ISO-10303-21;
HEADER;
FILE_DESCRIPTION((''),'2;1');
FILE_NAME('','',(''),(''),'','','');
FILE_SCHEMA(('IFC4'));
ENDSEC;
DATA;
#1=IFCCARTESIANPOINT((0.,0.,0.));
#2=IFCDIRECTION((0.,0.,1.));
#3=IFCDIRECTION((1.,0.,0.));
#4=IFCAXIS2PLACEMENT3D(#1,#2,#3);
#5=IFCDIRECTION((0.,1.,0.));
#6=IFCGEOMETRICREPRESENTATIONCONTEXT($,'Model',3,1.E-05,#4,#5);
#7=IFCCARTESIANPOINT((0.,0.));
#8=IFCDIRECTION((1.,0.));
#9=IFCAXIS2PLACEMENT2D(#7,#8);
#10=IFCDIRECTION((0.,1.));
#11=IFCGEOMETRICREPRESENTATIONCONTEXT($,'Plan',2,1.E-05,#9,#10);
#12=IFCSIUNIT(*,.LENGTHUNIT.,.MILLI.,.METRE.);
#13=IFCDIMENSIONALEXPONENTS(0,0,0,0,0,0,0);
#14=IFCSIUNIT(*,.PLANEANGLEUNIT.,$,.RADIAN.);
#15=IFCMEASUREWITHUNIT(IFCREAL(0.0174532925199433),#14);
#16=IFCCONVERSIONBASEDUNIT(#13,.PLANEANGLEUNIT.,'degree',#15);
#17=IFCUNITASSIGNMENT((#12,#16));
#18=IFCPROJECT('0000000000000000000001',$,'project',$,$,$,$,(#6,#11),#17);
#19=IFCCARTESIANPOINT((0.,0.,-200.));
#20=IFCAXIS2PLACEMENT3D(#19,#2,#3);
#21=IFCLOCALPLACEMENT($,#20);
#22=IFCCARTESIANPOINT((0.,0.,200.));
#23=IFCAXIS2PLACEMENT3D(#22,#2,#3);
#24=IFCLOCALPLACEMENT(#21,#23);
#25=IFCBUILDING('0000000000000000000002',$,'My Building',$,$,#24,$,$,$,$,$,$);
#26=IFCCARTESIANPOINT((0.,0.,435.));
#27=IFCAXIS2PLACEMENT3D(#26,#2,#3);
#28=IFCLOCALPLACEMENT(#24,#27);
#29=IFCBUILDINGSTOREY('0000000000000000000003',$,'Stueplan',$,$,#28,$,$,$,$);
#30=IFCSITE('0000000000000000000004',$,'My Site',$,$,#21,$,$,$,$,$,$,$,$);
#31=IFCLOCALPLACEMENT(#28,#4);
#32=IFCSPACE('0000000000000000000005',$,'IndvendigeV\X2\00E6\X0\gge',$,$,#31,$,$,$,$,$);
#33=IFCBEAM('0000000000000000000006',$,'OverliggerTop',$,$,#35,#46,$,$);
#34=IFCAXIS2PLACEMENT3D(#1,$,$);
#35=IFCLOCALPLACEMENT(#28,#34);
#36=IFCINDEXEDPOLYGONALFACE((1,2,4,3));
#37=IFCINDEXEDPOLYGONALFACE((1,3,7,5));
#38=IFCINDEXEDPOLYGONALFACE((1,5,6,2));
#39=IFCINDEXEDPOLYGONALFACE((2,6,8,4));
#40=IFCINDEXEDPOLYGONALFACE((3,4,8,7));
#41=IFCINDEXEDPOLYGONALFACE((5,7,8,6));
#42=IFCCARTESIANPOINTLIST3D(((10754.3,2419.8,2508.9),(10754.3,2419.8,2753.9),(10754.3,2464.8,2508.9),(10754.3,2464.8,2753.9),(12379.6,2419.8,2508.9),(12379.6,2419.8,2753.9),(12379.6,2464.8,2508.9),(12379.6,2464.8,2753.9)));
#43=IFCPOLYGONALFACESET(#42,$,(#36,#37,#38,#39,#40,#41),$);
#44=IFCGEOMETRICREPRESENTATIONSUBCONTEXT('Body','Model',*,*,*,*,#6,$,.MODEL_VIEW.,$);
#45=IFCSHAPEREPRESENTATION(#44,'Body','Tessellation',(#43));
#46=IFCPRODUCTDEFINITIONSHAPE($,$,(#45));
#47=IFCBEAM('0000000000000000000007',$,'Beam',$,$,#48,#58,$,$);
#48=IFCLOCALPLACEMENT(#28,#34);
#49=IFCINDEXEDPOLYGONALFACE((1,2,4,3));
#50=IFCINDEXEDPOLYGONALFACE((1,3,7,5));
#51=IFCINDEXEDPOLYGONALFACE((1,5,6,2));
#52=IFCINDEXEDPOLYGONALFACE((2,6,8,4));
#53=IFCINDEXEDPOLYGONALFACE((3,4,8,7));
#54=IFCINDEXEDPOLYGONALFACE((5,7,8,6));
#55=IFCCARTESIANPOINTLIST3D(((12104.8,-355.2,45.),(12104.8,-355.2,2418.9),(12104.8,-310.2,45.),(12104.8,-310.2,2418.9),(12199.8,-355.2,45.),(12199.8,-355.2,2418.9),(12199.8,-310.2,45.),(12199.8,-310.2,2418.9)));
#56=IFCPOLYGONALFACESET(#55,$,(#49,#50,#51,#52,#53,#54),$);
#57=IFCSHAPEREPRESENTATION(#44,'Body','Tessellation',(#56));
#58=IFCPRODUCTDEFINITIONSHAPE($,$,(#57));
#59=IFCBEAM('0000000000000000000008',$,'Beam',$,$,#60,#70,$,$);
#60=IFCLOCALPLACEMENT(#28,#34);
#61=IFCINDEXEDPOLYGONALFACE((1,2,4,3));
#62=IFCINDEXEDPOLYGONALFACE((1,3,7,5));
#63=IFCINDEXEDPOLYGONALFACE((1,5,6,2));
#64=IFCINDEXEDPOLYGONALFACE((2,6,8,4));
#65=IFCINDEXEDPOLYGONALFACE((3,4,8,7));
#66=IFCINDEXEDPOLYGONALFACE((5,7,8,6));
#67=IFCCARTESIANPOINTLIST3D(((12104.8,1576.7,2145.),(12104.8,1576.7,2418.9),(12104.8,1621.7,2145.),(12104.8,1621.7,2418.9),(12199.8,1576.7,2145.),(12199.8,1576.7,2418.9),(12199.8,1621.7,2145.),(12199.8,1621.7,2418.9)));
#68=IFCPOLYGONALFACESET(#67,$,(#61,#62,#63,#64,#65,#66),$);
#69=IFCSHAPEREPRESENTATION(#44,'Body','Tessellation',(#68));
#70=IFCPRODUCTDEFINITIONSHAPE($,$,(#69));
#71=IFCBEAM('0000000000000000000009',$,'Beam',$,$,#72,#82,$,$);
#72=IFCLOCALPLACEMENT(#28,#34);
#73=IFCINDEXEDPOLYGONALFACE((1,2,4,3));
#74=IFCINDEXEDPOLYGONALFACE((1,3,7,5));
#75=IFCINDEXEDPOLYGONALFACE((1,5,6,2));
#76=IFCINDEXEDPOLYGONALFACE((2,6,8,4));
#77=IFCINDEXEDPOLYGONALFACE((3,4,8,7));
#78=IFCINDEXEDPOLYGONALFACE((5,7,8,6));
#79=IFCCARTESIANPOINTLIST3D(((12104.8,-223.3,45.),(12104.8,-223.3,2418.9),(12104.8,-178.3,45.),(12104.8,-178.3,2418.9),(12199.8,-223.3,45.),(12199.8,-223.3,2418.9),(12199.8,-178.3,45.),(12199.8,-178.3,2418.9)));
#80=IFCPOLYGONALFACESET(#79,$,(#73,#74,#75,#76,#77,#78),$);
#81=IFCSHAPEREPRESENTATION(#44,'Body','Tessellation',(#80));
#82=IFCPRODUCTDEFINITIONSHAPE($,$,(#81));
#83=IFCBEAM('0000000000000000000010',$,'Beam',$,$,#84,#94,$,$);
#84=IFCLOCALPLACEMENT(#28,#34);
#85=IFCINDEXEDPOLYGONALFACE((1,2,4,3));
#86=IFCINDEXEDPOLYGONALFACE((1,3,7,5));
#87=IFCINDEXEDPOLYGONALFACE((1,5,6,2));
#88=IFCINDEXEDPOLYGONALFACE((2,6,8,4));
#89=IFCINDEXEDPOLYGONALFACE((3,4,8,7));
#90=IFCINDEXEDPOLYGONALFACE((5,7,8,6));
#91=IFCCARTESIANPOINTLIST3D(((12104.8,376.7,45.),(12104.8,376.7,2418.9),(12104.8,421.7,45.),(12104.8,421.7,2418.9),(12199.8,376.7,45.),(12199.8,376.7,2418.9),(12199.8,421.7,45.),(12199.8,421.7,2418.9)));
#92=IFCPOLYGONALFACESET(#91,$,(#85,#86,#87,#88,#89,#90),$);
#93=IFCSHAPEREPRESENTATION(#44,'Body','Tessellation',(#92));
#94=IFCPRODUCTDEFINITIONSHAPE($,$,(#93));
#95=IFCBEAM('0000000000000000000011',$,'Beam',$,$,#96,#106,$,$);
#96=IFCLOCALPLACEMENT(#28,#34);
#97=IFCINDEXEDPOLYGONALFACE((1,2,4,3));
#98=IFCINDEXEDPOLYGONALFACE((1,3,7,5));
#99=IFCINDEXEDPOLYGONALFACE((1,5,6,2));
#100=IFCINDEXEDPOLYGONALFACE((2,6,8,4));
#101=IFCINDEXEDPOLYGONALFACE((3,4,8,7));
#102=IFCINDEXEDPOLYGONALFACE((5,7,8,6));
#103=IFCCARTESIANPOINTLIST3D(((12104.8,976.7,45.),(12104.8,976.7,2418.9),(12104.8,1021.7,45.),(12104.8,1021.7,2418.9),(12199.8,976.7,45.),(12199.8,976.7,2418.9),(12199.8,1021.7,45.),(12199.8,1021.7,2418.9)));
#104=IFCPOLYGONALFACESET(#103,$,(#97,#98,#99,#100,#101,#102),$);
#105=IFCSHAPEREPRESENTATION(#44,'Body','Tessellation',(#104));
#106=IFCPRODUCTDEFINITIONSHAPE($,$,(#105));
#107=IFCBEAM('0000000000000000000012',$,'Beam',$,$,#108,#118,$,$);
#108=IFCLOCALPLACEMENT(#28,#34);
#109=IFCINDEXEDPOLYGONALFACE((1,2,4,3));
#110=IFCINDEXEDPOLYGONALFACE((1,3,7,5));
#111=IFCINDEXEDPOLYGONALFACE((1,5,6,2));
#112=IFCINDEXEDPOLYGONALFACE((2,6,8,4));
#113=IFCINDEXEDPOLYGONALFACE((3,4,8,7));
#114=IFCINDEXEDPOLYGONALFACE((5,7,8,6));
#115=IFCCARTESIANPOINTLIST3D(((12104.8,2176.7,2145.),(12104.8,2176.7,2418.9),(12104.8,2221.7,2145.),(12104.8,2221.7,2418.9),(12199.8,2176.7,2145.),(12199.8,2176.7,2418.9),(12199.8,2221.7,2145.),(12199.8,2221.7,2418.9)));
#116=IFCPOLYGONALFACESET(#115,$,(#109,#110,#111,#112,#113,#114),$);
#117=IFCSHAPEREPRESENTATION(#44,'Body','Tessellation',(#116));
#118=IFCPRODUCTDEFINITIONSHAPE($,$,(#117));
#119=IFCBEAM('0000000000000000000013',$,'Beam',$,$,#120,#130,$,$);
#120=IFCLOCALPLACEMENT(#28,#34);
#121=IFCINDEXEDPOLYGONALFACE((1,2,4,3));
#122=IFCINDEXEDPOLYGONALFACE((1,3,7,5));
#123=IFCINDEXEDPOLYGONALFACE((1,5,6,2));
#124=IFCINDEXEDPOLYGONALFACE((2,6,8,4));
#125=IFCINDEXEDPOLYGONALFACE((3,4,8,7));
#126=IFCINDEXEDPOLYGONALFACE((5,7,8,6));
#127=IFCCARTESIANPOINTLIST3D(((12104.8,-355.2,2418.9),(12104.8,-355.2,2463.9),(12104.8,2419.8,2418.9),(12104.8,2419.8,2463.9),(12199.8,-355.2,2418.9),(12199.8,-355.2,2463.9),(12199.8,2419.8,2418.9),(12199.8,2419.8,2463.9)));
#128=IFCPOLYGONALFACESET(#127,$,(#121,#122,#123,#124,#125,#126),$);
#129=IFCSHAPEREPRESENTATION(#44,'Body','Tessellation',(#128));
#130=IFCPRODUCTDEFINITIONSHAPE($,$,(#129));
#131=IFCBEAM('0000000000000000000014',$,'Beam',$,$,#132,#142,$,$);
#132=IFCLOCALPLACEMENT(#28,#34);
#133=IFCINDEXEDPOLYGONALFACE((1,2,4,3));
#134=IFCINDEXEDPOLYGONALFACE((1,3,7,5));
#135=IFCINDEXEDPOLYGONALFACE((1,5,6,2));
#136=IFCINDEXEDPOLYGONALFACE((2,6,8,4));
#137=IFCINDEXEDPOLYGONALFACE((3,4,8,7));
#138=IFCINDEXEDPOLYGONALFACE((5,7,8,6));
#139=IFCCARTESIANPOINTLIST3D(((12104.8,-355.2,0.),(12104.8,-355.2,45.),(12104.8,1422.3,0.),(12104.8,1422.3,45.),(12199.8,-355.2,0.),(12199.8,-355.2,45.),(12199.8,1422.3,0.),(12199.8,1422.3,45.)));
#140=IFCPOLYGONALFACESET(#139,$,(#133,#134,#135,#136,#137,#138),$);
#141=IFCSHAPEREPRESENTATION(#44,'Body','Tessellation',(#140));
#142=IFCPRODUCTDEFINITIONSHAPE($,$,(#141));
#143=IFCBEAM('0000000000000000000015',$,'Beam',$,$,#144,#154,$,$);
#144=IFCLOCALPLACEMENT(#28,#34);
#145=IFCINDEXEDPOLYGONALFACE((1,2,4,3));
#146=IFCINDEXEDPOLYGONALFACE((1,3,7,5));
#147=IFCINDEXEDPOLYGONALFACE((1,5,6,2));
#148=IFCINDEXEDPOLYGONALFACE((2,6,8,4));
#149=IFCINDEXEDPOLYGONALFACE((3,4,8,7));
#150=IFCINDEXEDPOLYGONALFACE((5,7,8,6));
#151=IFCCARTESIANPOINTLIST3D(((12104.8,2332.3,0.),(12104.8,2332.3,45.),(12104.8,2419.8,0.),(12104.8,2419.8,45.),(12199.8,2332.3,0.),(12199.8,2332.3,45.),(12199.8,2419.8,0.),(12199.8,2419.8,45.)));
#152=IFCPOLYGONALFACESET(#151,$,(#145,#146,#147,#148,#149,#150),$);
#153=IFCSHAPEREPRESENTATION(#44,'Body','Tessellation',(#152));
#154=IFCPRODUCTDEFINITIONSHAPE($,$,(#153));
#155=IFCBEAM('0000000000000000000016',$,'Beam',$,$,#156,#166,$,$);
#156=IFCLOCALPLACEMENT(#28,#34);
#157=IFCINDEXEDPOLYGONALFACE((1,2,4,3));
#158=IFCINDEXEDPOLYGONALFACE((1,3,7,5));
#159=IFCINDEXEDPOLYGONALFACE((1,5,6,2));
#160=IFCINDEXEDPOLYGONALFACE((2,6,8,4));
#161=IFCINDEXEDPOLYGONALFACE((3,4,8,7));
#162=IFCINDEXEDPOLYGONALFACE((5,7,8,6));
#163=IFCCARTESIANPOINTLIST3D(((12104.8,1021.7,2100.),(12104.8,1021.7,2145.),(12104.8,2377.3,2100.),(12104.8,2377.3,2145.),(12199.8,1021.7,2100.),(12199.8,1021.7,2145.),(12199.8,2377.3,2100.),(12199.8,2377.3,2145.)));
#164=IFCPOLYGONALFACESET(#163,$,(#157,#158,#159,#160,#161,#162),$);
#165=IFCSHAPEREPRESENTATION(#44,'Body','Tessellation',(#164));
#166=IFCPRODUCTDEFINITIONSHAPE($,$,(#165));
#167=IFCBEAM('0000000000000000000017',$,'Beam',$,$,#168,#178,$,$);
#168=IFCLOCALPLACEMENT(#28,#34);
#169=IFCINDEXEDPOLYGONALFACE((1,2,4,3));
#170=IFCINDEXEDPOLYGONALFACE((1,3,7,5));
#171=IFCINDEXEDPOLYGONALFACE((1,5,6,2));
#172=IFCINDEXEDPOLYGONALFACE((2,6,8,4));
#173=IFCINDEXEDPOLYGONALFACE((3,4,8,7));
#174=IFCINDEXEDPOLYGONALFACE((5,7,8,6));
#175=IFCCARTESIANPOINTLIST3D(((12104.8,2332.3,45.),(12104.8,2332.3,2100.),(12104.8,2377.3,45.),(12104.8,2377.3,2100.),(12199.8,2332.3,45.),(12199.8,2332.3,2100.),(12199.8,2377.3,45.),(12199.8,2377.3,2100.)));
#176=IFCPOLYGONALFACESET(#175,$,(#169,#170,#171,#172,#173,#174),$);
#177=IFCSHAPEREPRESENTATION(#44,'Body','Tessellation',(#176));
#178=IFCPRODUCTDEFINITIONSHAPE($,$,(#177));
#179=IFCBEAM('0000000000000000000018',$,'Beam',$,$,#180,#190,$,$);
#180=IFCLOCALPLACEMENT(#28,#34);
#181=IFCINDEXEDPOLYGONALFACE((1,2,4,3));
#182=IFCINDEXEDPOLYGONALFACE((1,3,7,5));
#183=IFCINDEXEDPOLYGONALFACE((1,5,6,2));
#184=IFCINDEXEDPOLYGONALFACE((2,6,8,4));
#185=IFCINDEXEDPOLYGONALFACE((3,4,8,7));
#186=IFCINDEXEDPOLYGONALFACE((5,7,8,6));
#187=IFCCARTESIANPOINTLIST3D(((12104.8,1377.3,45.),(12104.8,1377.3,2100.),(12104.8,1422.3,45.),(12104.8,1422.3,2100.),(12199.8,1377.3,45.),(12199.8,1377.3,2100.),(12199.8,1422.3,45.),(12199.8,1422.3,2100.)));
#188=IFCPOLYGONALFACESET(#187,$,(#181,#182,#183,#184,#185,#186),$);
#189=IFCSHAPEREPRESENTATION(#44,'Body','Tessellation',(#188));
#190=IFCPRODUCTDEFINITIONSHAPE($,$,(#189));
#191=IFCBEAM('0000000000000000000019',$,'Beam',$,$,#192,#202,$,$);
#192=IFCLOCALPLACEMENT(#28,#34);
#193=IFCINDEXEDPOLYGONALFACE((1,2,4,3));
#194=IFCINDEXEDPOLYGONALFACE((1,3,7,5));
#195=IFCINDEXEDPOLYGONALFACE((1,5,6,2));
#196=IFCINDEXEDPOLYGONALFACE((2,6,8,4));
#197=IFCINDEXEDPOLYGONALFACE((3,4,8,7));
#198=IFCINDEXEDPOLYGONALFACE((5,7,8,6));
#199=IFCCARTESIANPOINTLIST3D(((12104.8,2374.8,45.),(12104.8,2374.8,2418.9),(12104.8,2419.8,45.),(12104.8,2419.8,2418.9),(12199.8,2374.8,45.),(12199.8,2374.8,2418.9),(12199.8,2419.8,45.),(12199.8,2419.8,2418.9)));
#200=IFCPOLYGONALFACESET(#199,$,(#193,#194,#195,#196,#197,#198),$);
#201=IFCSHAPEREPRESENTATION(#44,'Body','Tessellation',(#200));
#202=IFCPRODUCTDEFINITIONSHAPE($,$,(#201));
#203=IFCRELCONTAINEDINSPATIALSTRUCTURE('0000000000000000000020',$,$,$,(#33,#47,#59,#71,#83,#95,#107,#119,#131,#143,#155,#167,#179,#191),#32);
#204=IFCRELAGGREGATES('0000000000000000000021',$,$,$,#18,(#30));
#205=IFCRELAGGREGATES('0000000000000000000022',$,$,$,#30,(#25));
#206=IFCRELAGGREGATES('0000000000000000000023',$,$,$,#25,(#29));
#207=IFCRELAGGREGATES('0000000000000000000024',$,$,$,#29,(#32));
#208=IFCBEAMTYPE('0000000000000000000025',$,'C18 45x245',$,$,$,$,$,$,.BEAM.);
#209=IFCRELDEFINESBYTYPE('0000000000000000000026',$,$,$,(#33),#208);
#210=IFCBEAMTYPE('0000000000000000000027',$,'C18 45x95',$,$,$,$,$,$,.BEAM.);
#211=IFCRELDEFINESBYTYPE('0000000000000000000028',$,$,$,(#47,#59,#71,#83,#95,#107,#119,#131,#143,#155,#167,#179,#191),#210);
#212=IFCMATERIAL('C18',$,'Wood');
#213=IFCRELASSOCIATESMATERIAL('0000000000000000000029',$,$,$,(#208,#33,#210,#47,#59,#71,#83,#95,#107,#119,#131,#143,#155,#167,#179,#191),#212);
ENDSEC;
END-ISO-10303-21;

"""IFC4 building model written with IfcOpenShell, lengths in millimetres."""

from ifc_helpers import new_model, entity, si_unit, converted_unit, direction, frame, origin_with_axes, origin_2d_with_axis, place, context, subcontext, project, spatial, rectangle, extrude, material, material_profile, profile_set, profile_usage, type_object, element, save


model = new_model("IFC4")

# Units and contexts
model_context = context("Model", 3, precision=1e-05, world=origin_with_axes(), true_north=direction((0.0, 1.0, 0.0)))
plan_context = context("Plan", 2, precision=1e-05, world=origin_2d_with_axis(), true_north=direction((0.0, 1.0)))
body_context_1 = subcontext(model_context, "Body", "Model", "MODEL_VIEW")
ifc_project = project(units=[si_unit("LENGTHUNIT", "METRE", prefix="MILLI"), converted_unit("PLANEANGLEUNIT", "degree", entity("IfcReal", 0.0174532925199433), si_unit("PLANEANGLEUNIT", "RADIAN"), dimensions=[0, 0, 0, 0, 0, 0, 0])], contexts=[model_context, plan_context])

# Site, building, storey
site_placement = place(None, frame((0.0, 0.0, -200.0), z_axis=(0.0, 0.0, 1.0), x_axis=(1.0, 0.0, 0.0)))
site = spatial("IfcSite", under=ifc_project, at=site_placement, Name="My Site")
building_placement = place(site_placement, frame((0.0, 0.0, 200.0), z_axis=(0.0, 0.0, 1.0), x_axis=(1.0, 0.0, 0.0)))
building = spatial("IfcBuilding", under=site, at=building_placement, Name="My Building")
storey_placement = place(building_placement, frame((0.0, 0.0, 435.0), z_axis=(0.0, 0.0, 1.0), x_axis=(1.0, 0.0, 0.0)))
storey = spatial("IfcBuildingStorey", under=building, at=storey_placement, Name="Stueplan")

# Shared definitions
ifc_material = material(Name="C18", Category="Wood")

# Shared definitions
space_1_placement = place(storey_placement, frame((0.0, 0.0, 0.0), z_axis=(0.0, 0.0, 1.0), x_axis=(1.0, 0.0, 0.0)))
space_1 = spatial("IfcSpace", under=storey, at=space_1_placement, Name="IndvendigeVægge")

# Beams
ifc_material_profile_1 = material_profile(ifc_material, rectangle(XDim=45.0, YDim=245.0), Name="concrete")
ifc_profile_set_1 = profile_set([ifc_material_profile_1], Name="woodStructural")
ifc_profile_usage_1 = profile_usage(ifc_profile_set_1)
beam_type_1 = type_object("IfcBeamType", Name="C18 45x245", PredefinedType="BEAM", material=ifc_profile_set_1)
beam_1_placement = place(space_1_placement, frame((12379.6, 2442.3, 2631.4), z_axis=(-1.0, 0.0, 0.0), x_axis=(0.0, 1.0, 0.0)))
element("IfcBeam", 1, at=beam_1_placement, inside=space_1, type_object=beam_type_1, material=ifc_profile_usage_1, Name="OverliggerTop", context=body_context_1, shape_type="SweptSolid", body=[
    extrude(rectangle(XDim=45.0, YDim=245.0), origin_with_axes(), (0.0, 0.0, 1.0), 1625.3),
])
ifc_material_profile_2 = material_profile(ifc_material, rectangle(XDim=45.0, YDim=95.0))
ifc_profile_set_2 = profile_set([ifc_material_profile_2], Name="woodStructural")
ifc_profile_usage_2 = profile_usage(ifc_profile_set_2)
beam_type_2 = type_object("IfcBeamType", Name="C18 45x95", PredefinedType="BEAM", material=ifc_profile_set_2)
beam_2_placement = place(space_1_placement, frame((12152.3, -332.7, 45.0), z_axis=(0.0, 0.0, 1.0), x_axis=(0.0, -1.0, 0.0)))
element("IfcBeam", 2, at=beam_2_placement, inside=space_1, type_object=beam_type_2, material=ifc_profile_usage_2, Name="Beam", context=body_context_1, shape_type="SweptSolid", body=[
    extrude(rectangle(XDim=45.0, YDim=95.0), origin_with_axes(), (0.0, 0.0, 1.0), 2373.9),
])
ifc_profile_usage_3 = profile_usage(ifc_profile_set_2)
beam_3_placement = place(space_1_placement, frame((12152.3, 1599.2, 2145.0), z_axis=(0.0, 0.0, 1.0), x_axis=(0.0, -1.0, 0.0)))
element("IfcBeam", 3, at=beam_3_placement, inside=space_1, type_object=beam_type_2, material=ifc_profile_usage_3, Name="Beam", context=body_context_1, shape_type="SweptSolid", body=[
    extrude(rectangle(XDim=45.0, YDim=95.0), origin_with_axes(), (0.0, 0.0, 1.0), 273.9),
])
ifc_profile_usage_4 = profile_usage(ifc_profile_set_2)
beam_4_placement = place(space_1_placement, frame((12152.3, -200.8, 45.0), z_axis=(0.0, 0.0, 1.0), x_axis=(0.0, -1.0, 0.0)))
element("IfcBeam", 4, at=beam_4_placement, inside=space_1, type_object=beam_type_2, material=ifc_profile_usage_4, Name="Beam", context=body_context_1, shape_type="SweptSolid", body=[
    extrude(rectangle(XDim=45.0, YDim=95.0), origin_with_axes(), (0.0, 0.0, 1.0), 2373.9),
])
ifc_profile_usage_5 = profile_usage(ifc_profile_set_2)
beam_5_placement = place(space_1_placement, frame((12152.3, 399.2, 45.0), z_axis=(0.0, 0.0, 1.0), x_axis=(0.0, -1.0, 0.0)))
element("IfcBeam", 5, at=beam_5_placement, inside=space_1, type_object=beam_type_2, material=ifc_profile_usage_5, Name="Beam", context=body_context_1, shape_type="SweptSolid", body=[
    extrude(rectangle(XDim=45.0, YDim=95.0), origin_with_axes(), (0.0, 0.0, 1.0), 2373.9),
])
ifc_profile_usage_6 = profile_usage(ifc_profile_set_2)
beam_6_placement = place(space_1_placement, frame((12152.3, 999.2, 45.0), z_axis=(0.0, 0.0, 1.0), x_axis=(0.0, -1.0, 0.0)))
element("IfcBeam", 6, at=beam_6_placement, inside=space_1, type_object=beam_type_2, material=ifc_profile_usage_6, Name="Beam", context=body_context_1, shape_type="SweptSolid", body=[
    extrude(rectangle(XDim=45.0, YDim=95.0), origin_with_axes(), (0.0, 0.0, 1.0), 2373.9),
])
ifc_profile_usage_7 = profile_usage(ifc_profile_set_2)
beam_7_placement = place(space_1_placement, frame((12152.3, 2199.2, 2145.0), z_axis=(0.0, 0.0, 1.0), x_axis=(0.0, -1.0, 0.0)))
element("IfcBeam", 7, at=beam_7_placement, inside=space_1, type_object=beam_type_2, material=ifc_profile_usage_7, Name="Beam", context=body_context_1, shape_type="SweptSolid", body=[
    extrude(rectangle(XDim=45.0, YDim=95.0), origin_with_axes(), (0.0, 0.0, 1.0), 273.9),
])
ifc_profile_usage_8 = profile_usage(ifc_profile_set_2, cardinal=5)
beam_8_placement = place(space_1_placement, frame((12152.3, -355.2, 2441.4), z_axis=(0.0, 1.0, 0.0), x_axis=(0.0, 0.0, 1.0)))
element("IfcBeam", 8, at=beam_8_placement, inside=space_1, type_object=beam_type_2, material=ifc_profile_usage_8, Name="Beam", context=body_context_1, shape_type="SweptSolid", body=[
    extrude(rectangle(XDim=45.0, YDim=95.0), origin_with_axes(), (0.0, 0.0, 1.0), 2775.0),
])
ifc_profile_usage_9 = profile_usage(ifc_profile_set_2, cardinal=5)
beam_9_placement = place(space_1_placement, frame((12152.3, -355.2, 22.5), z_axis=(0.0, 1.0, 0.0), x_axis=(0.0, 0.0, 1.0)))
element("IfcBeam", 9, at=beam_9_placement, inside=space_1, type_object=beam_type_2, material=ifc_profile_usage_9, Name="Beam", context=body_context_1, shape_type="SweptSolid", body=[
    extrude(rectangle(XDim=45.0, YDim=95.0), origin_with_axes(), (0.0, 0.0, 1.0), 1777.5),
])
ifc_profile_usage_10 = profile_usage(ifc_profile_set_2, cardinal=5)
beam_10_placement = place(space_1_placement, frame((12152.3, 2332.3, 22.5), z_axis=(0.0, 1.0, 0.0), x_axis=(0.0, 0.0, 1.0)))
element("IfcBeam", 10, at=beam_10_placement, inside=space_1, type_object=beam_type_2, material=ifc_profile_usage_10, Name="Beam", context=body_context_1, shape_type="SweptSolid", body=[
    extrude(rectangle(XDim=45.0, YDim=95.0), origin_with_axes(), (0.0, 0.0, 1.0), 87.5),
])
ifc_profile_usage_11 = profile_usage(ifc_profile_set_2, cardinal=5)
beam_11_placement = place(space_1_placement, frame((12152.3, 1021.7, 2122.5), z_axis=(0.0, 1.0, 0.0), x_axis=(0.0, 0.0, 1.0)))
element("IfcBeam", 11, at=beam_11_placement, inside=space_1, type_object=beam_type_2, material=ifc_profile_usage_11, Name="Beam", context=body_context_1, shape_type="SweptSolid", body=[
    extrude(rectangle(XDim=45.0, YDim=95.0), origin_with_axes(), (0.0, 0.0, 1.0), 1355.6),
])
ifc_profile_usage_12 = profile_usage(ifc_profile_set_2)
beam_12_placement = place(space_1_placement, frame((12152.3, 2354.8, 45.0), z_axis=(0.0, 0.0, 1.0), x_axis=(0.0, 1.0, 0.0)))
element("IfcBeam", 12, at=beam_12_placement, inside=space_1, type_object=beam_type_2, material=ifc_profile_usage_12, Name="Beam", context=body_context_1, shape_type="SweptSolid", body=[
    extrude(rectangle(XDim=45.0, YDim=95.0), origin_with_axes(), (0.0, 0.0, 1.0), 2055.0),
])
ifc_profile_usage_13 = profile_usage(ifc_profile_set_2)
beam_13_placement = place(space_1_placement, frame((12152.3, 1399.8, 45.0), z_axis=(0.0, 0.0, 1.0), x_axis=(0.0, 1.0, 0.0)))
element("IfcBeam", 13, at=beam_13_placement, inside=space_1, type_object=beam_type_2, material=ifc_profile_usage_13, Name="Beam", context=body_context_1, shape_type="SweptSolid", body=[
    extrude(rectangle(XDim=45.0, YDim=95.0), origin_with_axes(), (0.0, 0.0, 1.0), 2055.0),
])
ifc_profile_usage_14 = profile_usage(ifc_profile_set_2)
beam_14_placement = place(space_1_placement, frame((12152.3, 2397.3, 45.0), z_axis=(0.0, 0.0, 1.0), x_axis=(0.0, 1.0, 0.0)))
element("IfcBeam", 14, at=beam_14_placement, inside=space_1, type_object=beam_type_2, material=ifc_profile_usage_14, Name="Beam", context=body_context_1, shape_type="SweptSolid", body=[
    extrude(rectangle(XDim=45.0, YDim=95.0), origin_with_axes(), (0.0, 0.0, 1.0), 2373.9),
])

save(model, "model.ifc")
